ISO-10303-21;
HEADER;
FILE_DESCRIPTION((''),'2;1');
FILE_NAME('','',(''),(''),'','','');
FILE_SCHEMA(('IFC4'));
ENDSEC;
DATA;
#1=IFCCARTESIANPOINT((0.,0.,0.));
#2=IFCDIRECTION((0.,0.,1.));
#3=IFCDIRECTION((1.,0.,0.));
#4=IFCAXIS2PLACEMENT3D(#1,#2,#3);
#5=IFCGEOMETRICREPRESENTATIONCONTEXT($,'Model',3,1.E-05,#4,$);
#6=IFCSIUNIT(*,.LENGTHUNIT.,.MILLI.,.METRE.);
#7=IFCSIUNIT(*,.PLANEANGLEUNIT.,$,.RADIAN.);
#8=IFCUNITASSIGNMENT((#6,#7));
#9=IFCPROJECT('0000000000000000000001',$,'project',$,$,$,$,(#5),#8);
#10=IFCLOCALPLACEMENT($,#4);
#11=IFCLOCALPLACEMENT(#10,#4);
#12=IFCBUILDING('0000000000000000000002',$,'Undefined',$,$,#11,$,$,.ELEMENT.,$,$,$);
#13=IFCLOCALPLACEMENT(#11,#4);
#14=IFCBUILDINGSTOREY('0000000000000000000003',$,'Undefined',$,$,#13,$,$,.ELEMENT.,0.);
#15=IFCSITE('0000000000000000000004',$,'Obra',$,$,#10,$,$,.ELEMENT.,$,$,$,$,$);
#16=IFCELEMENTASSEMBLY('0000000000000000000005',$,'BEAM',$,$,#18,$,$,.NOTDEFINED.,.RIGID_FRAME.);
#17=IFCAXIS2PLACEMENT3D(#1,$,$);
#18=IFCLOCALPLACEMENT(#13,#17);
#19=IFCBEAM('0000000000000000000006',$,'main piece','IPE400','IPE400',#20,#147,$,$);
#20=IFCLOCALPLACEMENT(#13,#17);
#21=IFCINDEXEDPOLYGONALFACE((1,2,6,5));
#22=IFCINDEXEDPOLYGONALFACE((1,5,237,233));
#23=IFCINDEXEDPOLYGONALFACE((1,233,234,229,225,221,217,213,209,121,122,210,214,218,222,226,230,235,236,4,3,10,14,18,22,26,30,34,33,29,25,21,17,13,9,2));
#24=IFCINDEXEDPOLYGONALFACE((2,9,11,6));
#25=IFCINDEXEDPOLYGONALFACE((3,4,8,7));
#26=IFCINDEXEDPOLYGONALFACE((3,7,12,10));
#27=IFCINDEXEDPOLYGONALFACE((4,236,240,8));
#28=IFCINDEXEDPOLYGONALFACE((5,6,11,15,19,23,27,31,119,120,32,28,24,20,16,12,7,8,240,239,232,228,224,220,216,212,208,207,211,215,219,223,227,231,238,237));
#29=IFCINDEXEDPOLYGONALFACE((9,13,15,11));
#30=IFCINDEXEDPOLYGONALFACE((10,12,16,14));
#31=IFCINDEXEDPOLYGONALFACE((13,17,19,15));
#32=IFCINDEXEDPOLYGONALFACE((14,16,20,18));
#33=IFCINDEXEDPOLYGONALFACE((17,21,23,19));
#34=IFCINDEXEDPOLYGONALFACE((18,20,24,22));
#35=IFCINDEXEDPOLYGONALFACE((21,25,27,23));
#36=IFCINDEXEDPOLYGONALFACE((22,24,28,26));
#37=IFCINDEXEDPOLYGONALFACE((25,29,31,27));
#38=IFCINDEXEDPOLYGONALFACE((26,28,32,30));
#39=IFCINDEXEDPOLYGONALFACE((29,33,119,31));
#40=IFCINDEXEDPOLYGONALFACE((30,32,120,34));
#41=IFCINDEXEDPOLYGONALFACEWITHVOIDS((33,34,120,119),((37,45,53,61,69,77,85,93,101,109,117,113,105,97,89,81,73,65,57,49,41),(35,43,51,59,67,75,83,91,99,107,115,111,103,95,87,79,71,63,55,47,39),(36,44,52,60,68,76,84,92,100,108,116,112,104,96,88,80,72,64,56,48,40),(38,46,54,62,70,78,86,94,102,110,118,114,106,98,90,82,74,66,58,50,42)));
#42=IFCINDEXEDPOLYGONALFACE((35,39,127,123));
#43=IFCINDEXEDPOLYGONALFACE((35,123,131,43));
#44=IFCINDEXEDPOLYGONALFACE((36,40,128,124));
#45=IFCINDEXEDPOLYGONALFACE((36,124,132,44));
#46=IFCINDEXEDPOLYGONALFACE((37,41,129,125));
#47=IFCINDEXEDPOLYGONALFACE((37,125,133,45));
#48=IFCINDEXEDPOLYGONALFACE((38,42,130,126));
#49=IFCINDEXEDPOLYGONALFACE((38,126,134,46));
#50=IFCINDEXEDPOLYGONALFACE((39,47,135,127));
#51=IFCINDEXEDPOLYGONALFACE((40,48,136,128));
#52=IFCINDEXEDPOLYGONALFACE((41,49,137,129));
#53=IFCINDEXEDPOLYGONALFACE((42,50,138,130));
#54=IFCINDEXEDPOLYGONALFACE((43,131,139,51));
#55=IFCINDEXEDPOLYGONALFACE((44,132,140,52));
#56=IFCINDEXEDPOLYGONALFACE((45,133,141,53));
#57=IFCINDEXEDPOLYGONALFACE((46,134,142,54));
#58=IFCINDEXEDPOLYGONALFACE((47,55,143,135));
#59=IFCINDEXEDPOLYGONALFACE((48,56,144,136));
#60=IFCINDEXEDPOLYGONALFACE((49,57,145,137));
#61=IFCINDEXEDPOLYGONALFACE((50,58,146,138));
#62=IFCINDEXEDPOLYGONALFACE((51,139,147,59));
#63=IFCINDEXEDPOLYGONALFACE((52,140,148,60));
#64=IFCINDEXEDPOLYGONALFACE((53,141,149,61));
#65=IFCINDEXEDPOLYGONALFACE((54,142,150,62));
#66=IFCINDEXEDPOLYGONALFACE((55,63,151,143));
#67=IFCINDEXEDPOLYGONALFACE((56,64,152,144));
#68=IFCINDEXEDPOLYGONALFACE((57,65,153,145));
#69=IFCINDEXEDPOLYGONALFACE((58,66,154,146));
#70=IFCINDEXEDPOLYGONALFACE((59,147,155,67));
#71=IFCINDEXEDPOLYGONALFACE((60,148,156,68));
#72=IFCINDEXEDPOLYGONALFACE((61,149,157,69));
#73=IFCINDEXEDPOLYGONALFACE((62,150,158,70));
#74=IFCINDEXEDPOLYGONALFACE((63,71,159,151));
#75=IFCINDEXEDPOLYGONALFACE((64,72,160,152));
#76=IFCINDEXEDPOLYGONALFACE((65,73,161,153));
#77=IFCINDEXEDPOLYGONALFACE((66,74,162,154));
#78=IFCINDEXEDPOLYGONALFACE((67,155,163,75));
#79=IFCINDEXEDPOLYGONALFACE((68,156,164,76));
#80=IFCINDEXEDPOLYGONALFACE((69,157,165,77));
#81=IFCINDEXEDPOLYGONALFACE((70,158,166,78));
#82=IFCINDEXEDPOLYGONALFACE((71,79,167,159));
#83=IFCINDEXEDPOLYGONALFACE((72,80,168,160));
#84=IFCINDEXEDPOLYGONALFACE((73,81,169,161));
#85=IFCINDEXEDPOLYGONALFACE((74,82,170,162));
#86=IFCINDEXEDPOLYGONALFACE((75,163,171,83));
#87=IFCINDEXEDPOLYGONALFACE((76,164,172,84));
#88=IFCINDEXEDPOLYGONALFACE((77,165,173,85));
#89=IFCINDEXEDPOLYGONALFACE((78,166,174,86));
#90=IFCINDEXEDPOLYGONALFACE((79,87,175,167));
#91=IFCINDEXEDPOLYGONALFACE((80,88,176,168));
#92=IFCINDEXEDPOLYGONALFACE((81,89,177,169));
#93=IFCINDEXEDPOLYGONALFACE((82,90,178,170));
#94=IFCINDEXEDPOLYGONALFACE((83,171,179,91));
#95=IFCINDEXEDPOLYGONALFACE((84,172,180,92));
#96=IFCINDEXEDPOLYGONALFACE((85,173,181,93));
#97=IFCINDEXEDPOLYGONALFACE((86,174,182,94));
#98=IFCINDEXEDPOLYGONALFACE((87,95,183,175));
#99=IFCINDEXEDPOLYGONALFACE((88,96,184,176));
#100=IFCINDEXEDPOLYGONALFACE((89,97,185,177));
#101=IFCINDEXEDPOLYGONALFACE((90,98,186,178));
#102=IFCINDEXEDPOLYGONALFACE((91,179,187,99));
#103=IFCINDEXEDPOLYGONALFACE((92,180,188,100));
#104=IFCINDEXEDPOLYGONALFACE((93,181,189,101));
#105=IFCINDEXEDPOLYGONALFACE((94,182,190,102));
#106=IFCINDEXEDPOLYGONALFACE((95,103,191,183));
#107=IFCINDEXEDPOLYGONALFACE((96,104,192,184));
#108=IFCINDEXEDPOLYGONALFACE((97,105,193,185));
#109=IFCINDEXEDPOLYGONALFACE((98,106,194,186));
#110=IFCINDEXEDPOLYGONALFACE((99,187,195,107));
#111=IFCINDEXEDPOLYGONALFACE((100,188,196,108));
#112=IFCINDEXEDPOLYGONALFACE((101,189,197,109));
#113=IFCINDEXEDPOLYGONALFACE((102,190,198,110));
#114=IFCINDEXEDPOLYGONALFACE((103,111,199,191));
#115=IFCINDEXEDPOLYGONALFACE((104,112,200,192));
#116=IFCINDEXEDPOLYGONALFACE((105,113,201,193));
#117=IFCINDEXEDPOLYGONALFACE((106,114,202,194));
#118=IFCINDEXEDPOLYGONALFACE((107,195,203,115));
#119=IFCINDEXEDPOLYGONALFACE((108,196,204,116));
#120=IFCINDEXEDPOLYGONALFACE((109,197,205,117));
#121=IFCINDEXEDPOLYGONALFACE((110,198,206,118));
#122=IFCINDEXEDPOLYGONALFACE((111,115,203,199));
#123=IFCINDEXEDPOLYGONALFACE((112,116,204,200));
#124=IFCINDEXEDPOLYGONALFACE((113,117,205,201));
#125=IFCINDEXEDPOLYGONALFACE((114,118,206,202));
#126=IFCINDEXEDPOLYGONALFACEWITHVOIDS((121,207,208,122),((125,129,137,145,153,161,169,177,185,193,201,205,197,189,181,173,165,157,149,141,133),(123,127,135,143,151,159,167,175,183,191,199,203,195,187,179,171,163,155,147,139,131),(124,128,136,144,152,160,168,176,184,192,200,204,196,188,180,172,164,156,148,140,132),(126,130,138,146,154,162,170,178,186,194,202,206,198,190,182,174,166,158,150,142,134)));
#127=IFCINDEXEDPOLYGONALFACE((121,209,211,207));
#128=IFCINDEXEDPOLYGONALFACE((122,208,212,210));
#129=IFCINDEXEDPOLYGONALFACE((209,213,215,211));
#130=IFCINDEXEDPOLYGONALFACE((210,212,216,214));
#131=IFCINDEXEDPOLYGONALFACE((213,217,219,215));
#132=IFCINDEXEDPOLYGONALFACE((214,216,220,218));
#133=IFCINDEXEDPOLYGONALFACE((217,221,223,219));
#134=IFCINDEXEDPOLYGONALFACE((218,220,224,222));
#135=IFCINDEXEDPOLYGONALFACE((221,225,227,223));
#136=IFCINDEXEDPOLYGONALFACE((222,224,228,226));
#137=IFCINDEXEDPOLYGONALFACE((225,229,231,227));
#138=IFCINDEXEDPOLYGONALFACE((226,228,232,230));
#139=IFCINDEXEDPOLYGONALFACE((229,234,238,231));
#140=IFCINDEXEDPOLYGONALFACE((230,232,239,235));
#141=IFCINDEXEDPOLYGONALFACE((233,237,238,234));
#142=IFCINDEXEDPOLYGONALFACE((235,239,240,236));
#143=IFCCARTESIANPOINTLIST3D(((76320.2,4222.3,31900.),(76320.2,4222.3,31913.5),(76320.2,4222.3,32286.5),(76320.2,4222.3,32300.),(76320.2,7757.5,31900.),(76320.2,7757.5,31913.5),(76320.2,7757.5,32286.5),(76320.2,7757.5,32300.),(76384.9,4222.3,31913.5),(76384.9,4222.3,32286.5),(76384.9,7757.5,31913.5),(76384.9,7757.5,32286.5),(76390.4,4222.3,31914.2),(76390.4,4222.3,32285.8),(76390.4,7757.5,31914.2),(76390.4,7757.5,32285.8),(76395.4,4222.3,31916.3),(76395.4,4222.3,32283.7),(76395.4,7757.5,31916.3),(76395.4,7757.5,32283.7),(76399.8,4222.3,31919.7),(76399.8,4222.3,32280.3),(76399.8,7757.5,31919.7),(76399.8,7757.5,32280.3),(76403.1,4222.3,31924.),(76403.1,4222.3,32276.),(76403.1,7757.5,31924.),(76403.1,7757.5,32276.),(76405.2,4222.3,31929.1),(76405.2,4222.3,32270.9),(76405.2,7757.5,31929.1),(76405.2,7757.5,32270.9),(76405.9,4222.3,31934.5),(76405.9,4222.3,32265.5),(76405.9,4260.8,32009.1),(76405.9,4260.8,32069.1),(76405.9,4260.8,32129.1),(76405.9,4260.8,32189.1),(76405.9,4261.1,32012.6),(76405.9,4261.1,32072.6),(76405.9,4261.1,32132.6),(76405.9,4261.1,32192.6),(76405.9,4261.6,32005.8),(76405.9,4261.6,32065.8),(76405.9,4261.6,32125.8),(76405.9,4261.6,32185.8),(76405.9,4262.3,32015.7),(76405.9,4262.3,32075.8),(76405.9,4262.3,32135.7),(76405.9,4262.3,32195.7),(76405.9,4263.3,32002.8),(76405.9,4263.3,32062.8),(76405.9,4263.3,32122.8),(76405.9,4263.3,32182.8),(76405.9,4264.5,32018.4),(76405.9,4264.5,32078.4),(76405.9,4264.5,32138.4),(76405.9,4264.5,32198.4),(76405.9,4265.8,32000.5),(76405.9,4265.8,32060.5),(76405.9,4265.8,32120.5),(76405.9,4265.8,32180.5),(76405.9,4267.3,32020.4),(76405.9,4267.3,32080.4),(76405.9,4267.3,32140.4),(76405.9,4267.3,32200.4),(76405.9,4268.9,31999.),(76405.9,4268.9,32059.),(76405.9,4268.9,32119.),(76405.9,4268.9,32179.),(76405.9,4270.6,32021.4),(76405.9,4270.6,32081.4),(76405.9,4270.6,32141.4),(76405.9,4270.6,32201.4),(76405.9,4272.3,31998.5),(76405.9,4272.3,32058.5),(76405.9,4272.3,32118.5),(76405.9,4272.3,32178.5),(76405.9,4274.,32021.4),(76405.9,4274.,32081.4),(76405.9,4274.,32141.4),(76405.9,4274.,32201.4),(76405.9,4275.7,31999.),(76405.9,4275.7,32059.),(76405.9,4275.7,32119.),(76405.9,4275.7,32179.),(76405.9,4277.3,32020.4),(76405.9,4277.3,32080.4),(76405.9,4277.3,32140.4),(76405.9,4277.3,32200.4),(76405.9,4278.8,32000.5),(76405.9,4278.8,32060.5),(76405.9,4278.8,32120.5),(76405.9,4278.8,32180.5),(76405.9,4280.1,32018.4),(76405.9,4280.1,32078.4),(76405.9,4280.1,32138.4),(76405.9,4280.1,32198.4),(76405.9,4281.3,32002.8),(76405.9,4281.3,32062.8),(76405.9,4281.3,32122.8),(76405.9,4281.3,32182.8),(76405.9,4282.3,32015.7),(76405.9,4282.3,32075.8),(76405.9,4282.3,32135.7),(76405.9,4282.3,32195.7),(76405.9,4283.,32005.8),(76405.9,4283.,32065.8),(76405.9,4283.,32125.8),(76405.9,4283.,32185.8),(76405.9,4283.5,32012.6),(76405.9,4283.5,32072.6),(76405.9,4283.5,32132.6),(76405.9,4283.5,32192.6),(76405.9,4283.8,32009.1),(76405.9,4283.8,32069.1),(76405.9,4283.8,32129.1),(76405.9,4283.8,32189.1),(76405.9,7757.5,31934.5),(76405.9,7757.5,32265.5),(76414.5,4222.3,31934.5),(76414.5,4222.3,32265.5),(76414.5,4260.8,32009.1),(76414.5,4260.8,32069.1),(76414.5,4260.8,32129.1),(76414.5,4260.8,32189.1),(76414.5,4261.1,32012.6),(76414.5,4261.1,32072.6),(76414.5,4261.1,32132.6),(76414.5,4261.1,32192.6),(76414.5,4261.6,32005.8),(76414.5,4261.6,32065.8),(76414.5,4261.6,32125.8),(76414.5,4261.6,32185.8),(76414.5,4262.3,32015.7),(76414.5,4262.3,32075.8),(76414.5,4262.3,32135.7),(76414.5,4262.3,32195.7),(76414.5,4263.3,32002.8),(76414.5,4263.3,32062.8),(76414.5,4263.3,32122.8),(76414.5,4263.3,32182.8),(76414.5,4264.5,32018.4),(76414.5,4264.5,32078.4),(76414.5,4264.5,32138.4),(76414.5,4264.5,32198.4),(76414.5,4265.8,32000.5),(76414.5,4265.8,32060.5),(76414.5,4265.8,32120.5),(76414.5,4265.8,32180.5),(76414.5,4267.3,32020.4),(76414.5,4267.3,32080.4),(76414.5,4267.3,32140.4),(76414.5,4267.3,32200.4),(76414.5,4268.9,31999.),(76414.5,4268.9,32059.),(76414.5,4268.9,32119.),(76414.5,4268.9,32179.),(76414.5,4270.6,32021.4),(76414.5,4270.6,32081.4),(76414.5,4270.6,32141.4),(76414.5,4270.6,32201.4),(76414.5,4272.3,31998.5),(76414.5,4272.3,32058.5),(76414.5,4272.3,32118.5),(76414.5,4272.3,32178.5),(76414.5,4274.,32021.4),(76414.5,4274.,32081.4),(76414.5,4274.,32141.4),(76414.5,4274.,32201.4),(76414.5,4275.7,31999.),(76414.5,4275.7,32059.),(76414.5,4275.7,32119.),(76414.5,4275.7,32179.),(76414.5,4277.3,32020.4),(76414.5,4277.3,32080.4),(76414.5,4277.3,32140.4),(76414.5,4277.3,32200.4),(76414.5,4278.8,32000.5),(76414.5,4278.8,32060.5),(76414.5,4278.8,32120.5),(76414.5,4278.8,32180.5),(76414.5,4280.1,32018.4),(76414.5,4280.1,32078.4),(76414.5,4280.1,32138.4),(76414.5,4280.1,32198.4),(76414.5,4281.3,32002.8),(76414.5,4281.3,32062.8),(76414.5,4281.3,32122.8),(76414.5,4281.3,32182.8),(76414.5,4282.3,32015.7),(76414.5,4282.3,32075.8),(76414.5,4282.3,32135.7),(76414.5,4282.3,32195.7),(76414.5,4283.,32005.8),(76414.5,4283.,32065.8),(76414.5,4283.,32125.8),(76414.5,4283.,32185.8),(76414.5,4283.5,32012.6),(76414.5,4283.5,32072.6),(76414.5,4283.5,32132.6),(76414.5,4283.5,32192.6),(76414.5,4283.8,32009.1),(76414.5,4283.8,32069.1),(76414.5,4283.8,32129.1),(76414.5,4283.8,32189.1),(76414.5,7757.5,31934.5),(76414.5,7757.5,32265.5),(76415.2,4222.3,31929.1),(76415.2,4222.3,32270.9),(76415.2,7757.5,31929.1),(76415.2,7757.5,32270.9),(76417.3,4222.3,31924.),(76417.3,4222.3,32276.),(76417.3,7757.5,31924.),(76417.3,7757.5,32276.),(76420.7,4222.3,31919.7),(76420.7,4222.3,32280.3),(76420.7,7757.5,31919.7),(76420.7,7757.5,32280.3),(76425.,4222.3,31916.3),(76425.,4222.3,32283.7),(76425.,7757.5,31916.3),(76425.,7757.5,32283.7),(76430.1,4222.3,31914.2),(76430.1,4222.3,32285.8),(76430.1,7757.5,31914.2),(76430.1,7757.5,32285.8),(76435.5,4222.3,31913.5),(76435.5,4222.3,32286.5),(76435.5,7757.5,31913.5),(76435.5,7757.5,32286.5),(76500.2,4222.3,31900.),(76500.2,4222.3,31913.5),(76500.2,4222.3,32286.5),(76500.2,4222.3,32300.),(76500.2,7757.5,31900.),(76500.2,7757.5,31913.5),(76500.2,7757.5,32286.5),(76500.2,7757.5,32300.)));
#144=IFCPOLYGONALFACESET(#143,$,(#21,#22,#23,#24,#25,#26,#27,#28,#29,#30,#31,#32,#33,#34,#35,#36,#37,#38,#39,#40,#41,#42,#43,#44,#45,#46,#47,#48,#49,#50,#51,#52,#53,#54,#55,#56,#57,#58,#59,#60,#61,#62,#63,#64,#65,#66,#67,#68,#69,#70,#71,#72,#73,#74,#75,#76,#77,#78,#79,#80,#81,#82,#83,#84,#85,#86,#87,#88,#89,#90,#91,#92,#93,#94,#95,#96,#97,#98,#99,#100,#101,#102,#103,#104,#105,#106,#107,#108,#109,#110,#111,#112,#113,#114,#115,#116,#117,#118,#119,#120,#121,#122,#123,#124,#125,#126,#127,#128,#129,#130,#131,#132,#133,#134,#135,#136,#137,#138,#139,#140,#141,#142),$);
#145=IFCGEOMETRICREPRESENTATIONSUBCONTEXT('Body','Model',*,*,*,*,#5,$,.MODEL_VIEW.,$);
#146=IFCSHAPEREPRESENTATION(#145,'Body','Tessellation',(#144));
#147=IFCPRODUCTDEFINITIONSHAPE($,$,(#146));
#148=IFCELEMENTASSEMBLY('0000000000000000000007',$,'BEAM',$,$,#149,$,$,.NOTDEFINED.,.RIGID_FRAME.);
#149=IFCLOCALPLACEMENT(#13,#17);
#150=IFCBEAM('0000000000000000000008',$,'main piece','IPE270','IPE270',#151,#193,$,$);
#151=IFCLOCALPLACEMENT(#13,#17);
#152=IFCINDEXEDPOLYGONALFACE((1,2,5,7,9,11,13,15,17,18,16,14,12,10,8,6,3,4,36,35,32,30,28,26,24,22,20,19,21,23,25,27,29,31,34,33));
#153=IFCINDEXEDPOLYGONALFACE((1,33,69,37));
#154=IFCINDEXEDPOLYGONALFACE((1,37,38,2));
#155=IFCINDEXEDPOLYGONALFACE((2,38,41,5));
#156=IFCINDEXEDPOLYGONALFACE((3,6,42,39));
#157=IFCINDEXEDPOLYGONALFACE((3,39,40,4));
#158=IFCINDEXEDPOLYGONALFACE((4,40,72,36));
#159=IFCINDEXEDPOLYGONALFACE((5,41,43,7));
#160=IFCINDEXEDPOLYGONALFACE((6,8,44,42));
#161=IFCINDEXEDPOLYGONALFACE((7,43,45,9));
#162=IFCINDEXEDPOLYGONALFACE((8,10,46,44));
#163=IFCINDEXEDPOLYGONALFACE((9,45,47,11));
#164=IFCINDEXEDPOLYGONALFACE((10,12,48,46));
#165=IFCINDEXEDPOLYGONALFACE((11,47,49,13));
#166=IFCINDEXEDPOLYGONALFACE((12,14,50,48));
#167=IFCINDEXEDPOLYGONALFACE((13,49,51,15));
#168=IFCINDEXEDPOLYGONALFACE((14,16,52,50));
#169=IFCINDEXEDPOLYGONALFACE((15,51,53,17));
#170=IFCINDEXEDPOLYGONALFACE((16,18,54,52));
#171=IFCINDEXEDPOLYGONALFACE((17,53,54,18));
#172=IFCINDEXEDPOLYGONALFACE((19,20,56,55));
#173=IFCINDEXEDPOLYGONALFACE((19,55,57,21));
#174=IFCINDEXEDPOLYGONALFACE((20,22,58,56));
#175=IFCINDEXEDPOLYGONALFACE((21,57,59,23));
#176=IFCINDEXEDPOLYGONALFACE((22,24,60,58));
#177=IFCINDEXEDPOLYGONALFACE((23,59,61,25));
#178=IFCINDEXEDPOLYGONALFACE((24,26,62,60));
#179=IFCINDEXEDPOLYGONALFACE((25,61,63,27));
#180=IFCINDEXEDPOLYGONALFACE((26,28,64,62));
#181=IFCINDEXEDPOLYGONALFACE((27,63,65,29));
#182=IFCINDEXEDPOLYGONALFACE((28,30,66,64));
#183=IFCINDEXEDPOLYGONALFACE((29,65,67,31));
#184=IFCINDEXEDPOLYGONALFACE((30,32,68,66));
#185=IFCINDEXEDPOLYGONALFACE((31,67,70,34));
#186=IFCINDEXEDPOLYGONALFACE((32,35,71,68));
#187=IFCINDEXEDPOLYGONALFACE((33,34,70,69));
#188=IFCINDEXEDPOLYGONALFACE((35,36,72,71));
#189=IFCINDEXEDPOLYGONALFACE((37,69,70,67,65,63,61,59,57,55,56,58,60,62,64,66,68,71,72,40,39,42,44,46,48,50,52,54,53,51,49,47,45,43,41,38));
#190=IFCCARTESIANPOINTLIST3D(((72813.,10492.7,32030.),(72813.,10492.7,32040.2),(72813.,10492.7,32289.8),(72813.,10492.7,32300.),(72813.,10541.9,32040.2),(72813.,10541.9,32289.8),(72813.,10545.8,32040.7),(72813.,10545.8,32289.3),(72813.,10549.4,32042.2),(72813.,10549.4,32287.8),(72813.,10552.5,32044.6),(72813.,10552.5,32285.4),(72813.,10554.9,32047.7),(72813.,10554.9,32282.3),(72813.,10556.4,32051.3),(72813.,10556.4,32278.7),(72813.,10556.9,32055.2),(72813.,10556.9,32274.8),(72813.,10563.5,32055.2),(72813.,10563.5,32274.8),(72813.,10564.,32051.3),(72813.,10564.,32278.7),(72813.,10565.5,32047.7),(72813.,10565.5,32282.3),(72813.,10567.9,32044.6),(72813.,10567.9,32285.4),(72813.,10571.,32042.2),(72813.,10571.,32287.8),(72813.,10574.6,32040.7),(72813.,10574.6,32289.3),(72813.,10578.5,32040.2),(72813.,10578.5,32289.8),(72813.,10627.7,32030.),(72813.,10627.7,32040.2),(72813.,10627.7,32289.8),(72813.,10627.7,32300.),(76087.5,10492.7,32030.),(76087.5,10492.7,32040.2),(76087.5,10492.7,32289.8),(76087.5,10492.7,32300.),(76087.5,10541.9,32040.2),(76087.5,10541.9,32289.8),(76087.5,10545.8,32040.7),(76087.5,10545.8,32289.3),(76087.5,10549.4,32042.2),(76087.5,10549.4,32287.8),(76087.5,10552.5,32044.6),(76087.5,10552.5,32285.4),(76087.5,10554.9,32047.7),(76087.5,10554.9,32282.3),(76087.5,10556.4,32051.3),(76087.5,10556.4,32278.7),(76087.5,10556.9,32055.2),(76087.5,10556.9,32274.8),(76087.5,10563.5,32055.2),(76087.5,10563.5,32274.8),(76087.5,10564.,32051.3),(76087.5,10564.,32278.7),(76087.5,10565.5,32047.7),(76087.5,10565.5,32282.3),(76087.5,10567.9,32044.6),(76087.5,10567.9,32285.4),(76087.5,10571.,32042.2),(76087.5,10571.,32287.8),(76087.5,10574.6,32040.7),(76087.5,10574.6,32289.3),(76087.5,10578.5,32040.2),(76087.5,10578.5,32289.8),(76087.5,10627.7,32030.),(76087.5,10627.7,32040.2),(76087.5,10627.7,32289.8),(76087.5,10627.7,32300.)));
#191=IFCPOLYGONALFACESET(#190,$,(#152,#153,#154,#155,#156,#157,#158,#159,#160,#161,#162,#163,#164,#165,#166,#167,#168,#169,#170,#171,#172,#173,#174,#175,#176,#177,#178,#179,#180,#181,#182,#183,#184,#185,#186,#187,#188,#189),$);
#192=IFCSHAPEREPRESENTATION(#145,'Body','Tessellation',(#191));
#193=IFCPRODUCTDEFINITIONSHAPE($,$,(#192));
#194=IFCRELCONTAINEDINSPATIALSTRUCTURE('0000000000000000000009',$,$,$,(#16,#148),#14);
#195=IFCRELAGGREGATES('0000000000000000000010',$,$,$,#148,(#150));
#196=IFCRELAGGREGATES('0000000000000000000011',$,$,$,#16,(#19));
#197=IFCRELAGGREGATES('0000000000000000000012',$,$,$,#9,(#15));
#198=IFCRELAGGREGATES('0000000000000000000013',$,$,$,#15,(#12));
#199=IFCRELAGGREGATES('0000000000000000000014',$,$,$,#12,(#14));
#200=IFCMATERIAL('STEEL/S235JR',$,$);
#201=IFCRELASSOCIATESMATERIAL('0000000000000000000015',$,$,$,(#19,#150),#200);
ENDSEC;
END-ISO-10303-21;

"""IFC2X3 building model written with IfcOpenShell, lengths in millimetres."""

from ifc_helpers import new_model, si_unit, frame, origin_with_axes, origin_2d_with_axis, place, context, subcontext, project, spatial, circle, i_section, extrude, clip, halfspace, source, transform, mapped, material, element, aggregate, save


model = new_model("IFC2X3")

# Units and contexts
model_context = context("Model", 3, precision=1e-05, world=origin_with_axes())
body_context = subcontext(model_context, "Body", "Model", "MODEL_VIEW")
ifc_project = project(units=[si_unit("LENGTHUNIT", "METRE", prefix="MILLI"), si_unit("PLANEANGLEUNIT", "RADIAN")], contexts=[model_context])

# Site, building, storey
site_placement = place(None, origin_with_axes())
site = spatial("IfcSite", under=ifc_project, at=site_placement, Name="Obra", CompositionType="ELEMENT")
building_placement = place(site_placement, origin_with_axes())
building = spatial("IfcBuilding", under=site, at=building_placement, Name="Undefined", CompositionType="ELEMENT")
storey_placement = place(building_placement, origin_with_axes())
storey = spatial("IfcBuildingStorey", under=building, at=storey_placement, Name="Undefined", CompositionType="ELEMENT", Elevation=0.0)

# Shared definitions
ifc_material_1 = material(Name="STEEL/S235JR")

# Element assembly, beam, opening
assembly_1_placement = place(storey_placement, origin_with_axes())
assembly_1 = element("IfcElementAssembly", 1, at=assembly_1_placement, inside=storey, Name="BEAM", AssemblyPlace="NOTDEFINED", PredefinedType="RIGID_FRAME")
beam_1_placement = place(assembly_1_placement, frame((76410.2, 4059.9, 32100.0), z_axis=(0.0, 0.0, 1.0), x_axis=(0.0, 1.0, 0.0)))
beam_1 = element("IfcBeam", 2, at=beam_1_placement, material=ifc_material_1, Name="main piece", Description="IPE400", ObjectType="IPE400", context=body_context, shape_type="Clipping", body=[
    clip(extrude(i_section(OverallWidth=180.0, OverallDepth=400.0, WebThickness=8.6, FlangeThickness=13.5, FilletRadius=21.0, at=origin_2d_with_axis()), frame((3697.6, 0.0, 0.0), z_axis=(-1.0, 0.0, 0.0), x_axis=(0.0, -1.0, 0.0)), (0.0, 0.0, 1.0), 3535.2), halfspace(frame((162.4, 0.0, -300.0), z_axis=(1.0, 0.0, 0.0), x_axis=(0.0, -1.0, 0.0)), True)),
])
shared_shape_1 = source(origin_with_axes(), body_context, "Body", "SweptSolid", [
    extrude(circle(Radius=11.5, at=origin_2d_with_axis()), frame((0.0, -4.4, 0.0), z_axis=(0.0, 1.0, 0.0), x_axis=(1.0, 0.0, 0.0)), (0.0, 0.0, 1.0), 8.8),
])
opening_1_placement = place(assembly_1_placement, frame((76410.2, 4222.3, 32300.0), z_axis=(0.0, 1.0, 0.0), x_axis=(0.0, 0.0, -1.0)))
element("IfcOpeningElement", 3, at=opening_1_placement, cuts=beam_1, ObjectType="Opening", context=body_context, shape_type="MappedRepresentation", body=[
    mapped(shared_shape_1, transform((110.0, 0.0, 50.0))),
    mapped(shared_shape_1, transform((170.0, 0.0, 50.0))),
    mapped(shared_shape_1, transform((230.0, 0.0, 50.0))),
    mapped(shared_shape_1, transform((290.0, 0.0, 50.0))),
])

# Element assembly, beam
assembly_2_placement = place(storey_placement, origin_with_axes())
assembly_2 = element("IfcElementAssembly", 4, at=assembly_2_placement, inside=storey, Name="BEAM", AssemblyPlace="NOTDEFINED", PredefinedType="RIGID_FRAME")
beam_2_placement = place(assembly_2_placement, frame((72813.0, 10560.2, 32165.0), z_axis=(0.0, 0.0, 1.0), x_axis=(1.0, 0.0, 0.0)))
beam_2 = element("IfcBeam", 5, at=beam_2_placement, material=ifc_material_1, Name="main piece", Description="IPE270", ObjectType="IPE270", context=body_context, shape_type="SweptSolid", body=[
    extrude(i_section(OverallWidth=135.0, OverallDepth=270.0, WebThickness=6.6, FlangeThickness=10.2, FilletRadius=15.0, at=origin_2d_with_axis()), frame((3274.5, 0.0, 0.0), z_axis=(-1.0, 0.0, 0.0), x_axis=(0.0, -1.0, 0.0)), (0.0, 0.0, 1.0), 3274.5),
])
aggregate(assembly_2, [beam_2])

aggregate(assembly_1, [beam_1])

save(model, "model.ifc")
